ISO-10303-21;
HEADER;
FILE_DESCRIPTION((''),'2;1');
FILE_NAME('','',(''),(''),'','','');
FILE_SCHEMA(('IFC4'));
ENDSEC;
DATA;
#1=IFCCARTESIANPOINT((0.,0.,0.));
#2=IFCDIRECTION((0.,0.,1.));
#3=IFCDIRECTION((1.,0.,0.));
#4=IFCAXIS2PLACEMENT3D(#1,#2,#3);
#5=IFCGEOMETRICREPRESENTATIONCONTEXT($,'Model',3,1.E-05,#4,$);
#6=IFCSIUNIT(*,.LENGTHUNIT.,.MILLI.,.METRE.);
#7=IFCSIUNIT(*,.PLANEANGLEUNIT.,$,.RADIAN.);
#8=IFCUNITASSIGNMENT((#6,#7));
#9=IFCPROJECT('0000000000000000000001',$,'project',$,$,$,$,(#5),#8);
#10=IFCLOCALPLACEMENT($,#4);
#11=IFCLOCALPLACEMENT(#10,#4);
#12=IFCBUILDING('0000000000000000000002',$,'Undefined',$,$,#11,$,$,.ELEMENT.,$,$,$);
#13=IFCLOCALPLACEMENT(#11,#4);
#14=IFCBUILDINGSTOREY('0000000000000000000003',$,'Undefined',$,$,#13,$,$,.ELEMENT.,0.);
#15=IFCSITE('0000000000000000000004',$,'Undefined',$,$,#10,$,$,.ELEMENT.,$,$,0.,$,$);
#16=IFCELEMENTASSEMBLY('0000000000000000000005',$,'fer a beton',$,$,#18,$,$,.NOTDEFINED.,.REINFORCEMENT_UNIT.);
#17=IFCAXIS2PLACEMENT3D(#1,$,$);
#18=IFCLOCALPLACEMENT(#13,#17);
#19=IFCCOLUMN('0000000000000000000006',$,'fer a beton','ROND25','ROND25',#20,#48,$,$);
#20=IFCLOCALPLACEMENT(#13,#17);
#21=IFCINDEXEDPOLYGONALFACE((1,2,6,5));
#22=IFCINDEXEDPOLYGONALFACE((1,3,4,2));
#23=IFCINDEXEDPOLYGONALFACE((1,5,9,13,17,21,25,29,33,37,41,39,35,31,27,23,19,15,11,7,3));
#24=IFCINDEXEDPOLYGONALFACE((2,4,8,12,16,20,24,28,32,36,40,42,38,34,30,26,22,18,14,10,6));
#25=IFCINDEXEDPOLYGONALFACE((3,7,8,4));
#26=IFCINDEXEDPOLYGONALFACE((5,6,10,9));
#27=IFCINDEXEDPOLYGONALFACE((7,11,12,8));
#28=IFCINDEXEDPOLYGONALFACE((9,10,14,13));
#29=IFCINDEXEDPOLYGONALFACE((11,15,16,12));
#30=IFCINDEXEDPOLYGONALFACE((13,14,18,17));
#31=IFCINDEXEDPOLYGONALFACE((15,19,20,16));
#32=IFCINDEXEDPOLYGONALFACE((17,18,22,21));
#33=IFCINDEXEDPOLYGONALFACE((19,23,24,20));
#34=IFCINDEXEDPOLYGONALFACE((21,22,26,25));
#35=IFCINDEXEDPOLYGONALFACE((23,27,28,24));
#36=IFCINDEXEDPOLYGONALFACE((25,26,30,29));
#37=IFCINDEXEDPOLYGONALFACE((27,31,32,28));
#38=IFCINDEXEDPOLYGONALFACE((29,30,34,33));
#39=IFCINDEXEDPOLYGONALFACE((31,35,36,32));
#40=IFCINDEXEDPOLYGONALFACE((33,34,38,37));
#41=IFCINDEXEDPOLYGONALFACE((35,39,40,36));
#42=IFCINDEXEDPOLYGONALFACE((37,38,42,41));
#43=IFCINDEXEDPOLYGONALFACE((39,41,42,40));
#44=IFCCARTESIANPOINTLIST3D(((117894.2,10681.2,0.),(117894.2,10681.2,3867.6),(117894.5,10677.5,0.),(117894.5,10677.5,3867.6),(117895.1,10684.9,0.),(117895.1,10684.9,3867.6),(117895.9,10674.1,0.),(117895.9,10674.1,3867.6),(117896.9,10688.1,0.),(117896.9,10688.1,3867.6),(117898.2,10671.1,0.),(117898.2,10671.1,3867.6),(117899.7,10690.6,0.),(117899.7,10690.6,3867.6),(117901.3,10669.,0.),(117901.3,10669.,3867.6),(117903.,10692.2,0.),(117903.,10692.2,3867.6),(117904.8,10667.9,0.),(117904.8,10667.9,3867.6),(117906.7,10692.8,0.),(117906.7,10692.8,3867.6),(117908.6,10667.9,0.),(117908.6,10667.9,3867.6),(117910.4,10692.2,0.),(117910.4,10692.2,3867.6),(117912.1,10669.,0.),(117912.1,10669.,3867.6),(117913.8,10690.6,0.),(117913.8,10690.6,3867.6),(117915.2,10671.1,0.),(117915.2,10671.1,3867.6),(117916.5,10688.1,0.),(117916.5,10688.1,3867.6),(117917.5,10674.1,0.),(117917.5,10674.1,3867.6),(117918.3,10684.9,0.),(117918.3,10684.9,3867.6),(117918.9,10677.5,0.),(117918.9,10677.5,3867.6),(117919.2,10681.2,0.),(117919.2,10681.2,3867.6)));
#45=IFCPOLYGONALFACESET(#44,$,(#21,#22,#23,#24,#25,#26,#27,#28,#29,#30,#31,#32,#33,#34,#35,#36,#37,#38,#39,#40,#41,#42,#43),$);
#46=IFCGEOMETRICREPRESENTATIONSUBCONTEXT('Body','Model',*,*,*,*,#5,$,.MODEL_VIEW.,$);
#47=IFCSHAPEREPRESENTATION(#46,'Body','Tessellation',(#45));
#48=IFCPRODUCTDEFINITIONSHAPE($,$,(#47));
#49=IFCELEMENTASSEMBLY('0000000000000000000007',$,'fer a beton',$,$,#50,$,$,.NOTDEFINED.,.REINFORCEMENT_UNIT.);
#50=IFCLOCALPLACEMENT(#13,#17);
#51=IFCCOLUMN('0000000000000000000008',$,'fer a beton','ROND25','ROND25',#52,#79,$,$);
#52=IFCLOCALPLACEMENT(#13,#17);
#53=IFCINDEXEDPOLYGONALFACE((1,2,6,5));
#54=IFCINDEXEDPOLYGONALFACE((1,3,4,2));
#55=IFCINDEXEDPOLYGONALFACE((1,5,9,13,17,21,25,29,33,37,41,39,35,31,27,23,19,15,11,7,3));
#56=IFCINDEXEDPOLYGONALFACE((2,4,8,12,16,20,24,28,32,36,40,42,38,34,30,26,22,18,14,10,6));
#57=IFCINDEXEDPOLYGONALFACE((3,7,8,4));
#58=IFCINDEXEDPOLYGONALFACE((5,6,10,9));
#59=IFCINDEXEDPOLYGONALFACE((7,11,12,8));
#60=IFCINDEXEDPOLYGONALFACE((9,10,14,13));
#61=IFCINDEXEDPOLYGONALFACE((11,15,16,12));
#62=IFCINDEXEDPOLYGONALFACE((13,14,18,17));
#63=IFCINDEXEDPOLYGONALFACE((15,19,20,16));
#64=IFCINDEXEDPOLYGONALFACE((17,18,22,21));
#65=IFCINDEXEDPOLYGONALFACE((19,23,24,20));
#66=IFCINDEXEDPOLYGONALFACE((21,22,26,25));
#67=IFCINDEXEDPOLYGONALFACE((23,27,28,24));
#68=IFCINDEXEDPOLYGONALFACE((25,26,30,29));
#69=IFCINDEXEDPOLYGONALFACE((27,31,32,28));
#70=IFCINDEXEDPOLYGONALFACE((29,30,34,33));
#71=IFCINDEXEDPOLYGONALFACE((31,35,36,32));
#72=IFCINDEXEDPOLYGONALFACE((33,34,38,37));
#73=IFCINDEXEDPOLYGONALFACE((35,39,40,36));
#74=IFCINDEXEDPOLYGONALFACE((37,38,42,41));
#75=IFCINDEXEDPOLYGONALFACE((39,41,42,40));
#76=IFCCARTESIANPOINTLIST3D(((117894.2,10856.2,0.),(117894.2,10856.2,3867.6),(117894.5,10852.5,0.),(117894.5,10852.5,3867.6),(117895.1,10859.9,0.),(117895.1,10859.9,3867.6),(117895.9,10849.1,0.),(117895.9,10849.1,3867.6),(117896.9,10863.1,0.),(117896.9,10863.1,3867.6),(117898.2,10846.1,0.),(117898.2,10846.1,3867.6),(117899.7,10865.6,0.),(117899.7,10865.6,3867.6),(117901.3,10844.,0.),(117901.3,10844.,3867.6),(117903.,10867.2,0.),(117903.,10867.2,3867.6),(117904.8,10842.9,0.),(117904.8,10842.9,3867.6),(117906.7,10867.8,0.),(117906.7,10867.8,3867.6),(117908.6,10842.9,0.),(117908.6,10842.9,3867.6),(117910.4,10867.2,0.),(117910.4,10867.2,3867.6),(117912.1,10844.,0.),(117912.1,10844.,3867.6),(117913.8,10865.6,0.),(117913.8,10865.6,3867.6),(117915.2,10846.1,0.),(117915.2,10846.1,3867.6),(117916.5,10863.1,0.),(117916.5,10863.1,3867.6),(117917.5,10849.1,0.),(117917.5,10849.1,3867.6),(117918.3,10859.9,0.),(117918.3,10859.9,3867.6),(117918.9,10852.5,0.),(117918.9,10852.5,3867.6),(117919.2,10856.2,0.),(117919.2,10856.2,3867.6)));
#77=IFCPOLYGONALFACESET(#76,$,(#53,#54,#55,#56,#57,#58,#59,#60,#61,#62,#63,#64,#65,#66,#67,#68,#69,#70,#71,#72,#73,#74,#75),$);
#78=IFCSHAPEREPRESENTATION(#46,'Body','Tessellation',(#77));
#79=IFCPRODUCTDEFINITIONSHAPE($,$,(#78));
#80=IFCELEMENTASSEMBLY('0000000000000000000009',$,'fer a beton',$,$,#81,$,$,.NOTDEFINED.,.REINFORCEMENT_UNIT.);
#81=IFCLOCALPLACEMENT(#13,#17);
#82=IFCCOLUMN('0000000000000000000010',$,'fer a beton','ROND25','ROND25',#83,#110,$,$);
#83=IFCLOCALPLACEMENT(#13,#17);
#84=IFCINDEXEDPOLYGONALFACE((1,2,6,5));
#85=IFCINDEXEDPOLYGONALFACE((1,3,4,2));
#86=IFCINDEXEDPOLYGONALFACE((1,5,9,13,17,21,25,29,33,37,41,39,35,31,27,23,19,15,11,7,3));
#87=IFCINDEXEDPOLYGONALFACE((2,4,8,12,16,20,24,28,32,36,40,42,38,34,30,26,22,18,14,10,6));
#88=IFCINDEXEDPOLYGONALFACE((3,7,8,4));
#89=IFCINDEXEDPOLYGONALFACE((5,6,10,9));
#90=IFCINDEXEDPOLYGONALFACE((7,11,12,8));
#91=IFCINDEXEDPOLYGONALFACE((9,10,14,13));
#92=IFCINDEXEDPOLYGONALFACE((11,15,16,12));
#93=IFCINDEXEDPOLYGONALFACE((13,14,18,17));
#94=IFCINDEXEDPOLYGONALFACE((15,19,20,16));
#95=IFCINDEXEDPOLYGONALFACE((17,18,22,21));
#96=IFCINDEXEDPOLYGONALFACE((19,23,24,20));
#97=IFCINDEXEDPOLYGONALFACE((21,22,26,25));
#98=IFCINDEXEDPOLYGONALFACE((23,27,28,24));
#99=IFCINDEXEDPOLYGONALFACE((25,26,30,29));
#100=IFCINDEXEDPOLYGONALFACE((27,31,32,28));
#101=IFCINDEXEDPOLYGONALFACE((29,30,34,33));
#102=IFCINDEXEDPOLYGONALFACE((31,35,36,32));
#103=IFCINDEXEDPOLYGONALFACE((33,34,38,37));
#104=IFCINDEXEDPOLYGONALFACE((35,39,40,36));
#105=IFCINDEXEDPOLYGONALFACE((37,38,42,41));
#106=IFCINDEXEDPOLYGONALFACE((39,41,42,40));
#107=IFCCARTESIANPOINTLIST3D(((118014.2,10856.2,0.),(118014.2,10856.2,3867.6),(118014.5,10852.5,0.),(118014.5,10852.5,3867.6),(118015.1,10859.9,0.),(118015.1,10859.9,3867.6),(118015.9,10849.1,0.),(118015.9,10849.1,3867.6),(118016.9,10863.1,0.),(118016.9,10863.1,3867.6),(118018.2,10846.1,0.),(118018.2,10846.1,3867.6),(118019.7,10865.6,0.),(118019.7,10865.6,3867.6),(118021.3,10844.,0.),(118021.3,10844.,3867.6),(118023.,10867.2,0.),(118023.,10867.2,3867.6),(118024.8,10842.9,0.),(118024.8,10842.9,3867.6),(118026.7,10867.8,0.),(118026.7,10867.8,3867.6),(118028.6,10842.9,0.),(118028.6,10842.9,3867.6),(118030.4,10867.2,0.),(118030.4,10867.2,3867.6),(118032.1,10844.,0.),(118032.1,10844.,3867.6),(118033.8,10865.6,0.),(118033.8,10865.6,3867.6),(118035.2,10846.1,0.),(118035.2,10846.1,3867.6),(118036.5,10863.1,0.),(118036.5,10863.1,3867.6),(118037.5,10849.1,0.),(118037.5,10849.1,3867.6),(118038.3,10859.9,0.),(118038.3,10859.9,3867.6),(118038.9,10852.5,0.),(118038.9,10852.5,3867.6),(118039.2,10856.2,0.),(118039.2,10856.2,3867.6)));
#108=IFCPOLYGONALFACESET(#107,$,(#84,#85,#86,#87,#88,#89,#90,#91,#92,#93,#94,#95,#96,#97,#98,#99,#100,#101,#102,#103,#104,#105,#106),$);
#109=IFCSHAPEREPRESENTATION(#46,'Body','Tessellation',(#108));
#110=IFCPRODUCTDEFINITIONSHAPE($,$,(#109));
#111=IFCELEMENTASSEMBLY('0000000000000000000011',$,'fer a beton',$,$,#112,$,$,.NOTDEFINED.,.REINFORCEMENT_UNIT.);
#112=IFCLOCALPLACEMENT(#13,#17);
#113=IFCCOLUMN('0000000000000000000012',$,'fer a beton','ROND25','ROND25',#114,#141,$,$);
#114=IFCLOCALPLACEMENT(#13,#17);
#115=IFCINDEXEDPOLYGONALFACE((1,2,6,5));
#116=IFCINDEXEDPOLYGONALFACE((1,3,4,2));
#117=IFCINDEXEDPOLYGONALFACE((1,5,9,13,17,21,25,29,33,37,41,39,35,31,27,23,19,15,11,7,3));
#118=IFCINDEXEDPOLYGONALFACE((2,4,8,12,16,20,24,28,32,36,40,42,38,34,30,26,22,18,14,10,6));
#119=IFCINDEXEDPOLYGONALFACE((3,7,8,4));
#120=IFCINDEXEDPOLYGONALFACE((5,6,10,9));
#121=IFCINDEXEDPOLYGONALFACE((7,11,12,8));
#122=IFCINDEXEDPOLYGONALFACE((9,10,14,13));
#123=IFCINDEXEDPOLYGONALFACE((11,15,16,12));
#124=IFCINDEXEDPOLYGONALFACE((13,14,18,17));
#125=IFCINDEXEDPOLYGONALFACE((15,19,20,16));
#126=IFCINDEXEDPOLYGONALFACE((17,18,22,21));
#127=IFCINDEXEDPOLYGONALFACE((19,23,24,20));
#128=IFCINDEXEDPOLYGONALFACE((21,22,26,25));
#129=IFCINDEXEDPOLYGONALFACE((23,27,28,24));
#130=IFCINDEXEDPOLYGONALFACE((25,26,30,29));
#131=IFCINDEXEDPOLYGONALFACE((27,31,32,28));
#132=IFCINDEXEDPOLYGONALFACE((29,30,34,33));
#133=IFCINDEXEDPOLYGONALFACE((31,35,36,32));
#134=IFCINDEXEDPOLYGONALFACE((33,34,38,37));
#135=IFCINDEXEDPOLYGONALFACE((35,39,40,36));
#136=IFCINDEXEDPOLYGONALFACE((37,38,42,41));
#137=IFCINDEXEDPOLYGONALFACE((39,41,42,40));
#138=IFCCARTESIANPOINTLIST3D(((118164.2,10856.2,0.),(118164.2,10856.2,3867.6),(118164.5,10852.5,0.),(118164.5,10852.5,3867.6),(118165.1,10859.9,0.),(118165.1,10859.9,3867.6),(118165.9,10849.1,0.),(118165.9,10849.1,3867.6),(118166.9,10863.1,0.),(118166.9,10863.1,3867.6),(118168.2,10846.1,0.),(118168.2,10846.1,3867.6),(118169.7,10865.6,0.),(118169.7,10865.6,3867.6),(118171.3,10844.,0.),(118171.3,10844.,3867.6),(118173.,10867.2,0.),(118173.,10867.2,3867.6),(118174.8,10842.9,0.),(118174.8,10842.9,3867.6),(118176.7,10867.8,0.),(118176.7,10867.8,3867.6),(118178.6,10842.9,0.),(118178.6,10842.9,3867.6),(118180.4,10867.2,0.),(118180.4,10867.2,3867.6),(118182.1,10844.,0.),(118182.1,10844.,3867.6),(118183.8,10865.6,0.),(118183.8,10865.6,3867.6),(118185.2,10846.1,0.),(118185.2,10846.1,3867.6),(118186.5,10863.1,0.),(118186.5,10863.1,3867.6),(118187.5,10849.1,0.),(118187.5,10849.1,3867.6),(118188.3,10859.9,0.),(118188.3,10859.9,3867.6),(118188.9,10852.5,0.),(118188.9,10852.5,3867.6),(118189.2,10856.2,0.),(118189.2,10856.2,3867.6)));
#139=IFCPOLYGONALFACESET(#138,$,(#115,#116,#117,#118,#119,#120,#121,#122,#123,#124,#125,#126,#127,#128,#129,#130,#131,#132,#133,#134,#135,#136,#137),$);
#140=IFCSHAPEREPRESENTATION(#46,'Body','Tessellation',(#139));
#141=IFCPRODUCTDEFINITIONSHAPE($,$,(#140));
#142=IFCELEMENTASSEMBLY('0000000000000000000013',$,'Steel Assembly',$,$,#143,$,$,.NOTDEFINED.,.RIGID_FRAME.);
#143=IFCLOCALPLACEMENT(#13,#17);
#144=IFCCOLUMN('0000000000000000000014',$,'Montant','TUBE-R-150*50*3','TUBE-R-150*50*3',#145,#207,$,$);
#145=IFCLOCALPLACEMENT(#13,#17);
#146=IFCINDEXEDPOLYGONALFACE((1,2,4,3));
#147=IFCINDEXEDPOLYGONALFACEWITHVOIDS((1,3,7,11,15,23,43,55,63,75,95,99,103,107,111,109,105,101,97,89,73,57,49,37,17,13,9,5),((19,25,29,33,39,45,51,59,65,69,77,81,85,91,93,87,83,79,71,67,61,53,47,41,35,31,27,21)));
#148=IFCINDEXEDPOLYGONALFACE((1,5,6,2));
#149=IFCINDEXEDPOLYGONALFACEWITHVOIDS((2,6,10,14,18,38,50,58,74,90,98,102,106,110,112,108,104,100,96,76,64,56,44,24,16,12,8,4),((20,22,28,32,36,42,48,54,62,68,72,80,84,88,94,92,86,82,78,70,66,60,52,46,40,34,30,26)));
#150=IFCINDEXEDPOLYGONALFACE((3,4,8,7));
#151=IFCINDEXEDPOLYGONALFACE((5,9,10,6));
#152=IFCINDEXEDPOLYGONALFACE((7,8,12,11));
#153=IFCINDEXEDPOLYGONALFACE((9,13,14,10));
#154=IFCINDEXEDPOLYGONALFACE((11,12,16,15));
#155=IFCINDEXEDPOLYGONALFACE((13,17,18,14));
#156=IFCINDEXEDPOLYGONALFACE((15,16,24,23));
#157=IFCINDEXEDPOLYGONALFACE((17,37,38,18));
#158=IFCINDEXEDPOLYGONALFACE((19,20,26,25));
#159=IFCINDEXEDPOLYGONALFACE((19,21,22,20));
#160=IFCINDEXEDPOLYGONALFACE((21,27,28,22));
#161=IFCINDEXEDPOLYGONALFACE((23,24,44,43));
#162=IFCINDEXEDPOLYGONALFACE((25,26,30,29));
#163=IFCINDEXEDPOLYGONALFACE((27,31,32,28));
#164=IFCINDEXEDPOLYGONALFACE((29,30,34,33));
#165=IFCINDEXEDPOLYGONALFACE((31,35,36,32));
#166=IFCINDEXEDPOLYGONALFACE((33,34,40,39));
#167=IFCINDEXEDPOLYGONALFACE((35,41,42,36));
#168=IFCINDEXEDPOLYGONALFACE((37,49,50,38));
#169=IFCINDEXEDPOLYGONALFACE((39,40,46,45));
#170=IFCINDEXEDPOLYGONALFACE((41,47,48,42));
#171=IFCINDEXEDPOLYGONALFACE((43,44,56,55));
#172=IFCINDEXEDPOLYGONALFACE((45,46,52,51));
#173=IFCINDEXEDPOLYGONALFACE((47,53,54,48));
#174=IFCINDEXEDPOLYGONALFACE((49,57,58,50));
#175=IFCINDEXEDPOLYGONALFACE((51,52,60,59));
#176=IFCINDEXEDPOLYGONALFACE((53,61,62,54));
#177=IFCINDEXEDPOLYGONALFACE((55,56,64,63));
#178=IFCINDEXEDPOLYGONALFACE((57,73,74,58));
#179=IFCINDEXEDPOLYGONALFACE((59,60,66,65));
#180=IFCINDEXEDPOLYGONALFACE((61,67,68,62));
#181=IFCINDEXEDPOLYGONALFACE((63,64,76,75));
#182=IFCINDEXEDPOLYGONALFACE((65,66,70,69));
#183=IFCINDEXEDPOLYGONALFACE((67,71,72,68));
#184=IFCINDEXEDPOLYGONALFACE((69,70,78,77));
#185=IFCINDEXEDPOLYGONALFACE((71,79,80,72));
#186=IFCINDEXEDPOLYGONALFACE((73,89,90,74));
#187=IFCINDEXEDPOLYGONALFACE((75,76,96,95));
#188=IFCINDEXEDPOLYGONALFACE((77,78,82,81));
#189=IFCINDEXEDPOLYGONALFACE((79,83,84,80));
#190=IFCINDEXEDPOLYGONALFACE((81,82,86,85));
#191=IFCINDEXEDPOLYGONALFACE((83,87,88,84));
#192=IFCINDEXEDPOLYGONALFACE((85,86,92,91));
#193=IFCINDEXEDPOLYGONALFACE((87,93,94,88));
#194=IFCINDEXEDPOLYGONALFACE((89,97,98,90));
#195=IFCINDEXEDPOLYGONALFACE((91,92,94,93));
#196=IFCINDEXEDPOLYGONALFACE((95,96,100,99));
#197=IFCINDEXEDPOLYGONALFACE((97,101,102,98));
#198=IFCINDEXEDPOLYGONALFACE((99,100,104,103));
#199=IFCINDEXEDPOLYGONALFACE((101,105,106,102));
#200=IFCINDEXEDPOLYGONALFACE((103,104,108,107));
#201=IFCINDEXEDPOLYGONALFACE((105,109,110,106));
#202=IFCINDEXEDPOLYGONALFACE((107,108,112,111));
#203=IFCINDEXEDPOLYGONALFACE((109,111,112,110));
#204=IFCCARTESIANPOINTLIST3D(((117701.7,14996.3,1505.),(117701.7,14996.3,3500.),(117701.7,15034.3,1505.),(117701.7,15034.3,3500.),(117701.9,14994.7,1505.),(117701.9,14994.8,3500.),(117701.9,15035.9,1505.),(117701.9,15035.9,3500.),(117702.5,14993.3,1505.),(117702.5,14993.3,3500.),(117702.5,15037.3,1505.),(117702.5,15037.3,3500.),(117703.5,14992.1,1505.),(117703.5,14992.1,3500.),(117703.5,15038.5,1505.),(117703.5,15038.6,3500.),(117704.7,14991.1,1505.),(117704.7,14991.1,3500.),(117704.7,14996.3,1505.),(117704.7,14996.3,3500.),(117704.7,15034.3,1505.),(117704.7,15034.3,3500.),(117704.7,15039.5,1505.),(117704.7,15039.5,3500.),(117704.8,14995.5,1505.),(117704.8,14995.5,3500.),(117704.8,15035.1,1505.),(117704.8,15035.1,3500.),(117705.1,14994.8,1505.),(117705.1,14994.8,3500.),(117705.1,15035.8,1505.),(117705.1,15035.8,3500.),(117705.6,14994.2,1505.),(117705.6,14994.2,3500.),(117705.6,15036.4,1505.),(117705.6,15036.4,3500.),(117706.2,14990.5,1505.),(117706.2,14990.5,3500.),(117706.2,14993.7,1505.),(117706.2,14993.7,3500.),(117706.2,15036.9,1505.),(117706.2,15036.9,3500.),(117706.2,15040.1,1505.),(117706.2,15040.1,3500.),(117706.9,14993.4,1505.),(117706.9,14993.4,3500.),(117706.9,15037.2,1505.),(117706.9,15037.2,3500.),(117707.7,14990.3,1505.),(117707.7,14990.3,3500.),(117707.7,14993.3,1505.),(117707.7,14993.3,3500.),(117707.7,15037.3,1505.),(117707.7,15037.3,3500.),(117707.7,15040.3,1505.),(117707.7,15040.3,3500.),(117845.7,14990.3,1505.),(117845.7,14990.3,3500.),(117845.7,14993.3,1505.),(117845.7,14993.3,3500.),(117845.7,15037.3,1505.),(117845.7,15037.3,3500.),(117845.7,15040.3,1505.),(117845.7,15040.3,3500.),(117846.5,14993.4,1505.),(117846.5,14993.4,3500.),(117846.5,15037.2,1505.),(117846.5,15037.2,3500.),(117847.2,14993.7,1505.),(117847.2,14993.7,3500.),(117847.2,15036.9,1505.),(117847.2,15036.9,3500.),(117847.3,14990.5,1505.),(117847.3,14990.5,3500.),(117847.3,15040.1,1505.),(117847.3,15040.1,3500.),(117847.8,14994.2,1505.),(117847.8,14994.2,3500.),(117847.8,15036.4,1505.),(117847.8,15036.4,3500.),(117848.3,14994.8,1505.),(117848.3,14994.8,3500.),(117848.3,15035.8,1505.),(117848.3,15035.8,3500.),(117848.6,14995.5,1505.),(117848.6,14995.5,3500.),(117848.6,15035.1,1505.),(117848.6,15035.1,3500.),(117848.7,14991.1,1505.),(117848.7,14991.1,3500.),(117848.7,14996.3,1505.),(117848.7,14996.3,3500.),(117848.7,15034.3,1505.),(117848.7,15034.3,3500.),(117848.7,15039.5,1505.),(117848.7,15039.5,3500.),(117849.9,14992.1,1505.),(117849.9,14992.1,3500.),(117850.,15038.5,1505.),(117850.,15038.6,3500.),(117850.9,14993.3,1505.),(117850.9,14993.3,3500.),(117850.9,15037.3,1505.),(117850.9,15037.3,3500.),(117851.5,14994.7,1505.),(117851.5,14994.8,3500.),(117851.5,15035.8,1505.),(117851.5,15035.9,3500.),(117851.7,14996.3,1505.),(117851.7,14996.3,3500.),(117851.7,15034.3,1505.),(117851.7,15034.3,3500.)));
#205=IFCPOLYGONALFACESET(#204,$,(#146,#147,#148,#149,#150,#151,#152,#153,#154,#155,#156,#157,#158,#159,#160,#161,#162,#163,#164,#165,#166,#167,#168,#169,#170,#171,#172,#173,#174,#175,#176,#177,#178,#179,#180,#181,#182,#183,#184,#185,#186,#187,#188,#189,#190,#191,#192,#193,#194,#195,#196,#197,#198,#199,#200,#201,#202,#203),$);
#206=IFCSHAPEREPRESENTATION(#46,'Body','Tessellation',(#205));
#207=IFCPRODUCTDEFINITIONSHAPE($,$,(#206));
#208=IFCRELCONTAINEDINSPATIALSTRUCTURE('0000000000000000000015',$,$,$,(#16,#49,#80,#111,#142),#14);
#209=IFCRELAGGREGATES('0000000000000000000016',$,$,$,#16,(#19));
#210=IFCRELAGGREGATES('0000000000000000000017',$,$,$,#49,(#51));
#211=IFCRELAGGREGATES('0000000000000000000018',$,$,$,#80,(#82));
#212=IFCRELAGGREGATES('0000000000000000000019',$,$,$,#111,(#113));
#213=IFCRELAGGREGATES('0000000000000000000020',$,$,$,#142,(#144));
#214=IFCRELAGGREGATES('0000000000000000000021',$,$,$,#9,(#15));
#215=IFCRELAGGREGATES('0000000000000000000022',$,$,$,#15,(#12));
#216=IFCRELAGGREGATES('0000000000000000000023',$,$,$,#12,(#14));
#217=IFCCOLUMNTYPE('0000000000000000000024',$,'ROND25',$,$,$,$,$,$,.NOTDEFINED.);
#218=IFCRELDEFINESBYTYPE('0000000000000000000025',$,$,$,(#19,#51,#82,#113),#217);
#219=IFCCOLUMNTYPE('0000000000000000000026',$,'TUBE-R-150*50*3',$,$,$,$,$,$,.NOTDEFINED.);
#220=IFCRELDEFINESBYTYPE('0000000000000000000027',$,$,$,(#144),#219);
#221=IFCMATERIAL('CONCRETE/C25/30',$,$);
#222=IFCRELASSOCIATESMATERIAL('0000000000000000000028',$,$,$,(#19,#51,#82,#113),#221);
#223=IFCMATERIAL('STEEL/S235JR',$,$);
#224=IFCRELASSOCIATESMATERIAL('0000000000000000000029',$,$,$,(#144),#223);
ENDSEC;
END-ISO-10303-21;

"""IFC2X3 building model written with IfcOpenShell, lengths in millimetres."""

from ifc_helpers import new_model, si_unit, frame, origin_with_axes, origin_2d_with_axis, place, context, subcontext, project, spatial, hollow_rectangle, circle, extrude, material, type_object, element, aggregate, save


model = new_model("IFC2X3")

# Units and contexts
model_context = context("Model", 3, precision=1e-05, world=origin_with_axes())
body_context = subcontext(model_context, "Body", "Model", "MODEL_VIEW")
ifc_project = project(units=[si_unit("LENGTHUNIT", "METRE", prefix="MILLI"), si_unit("PLANEANGLEUNIT", "RADIAN")], contexts=[model_context])

# Site, building, storey
site_placement = place(None, origin_with_axes())
site = spatial("IfcSite", under=ifc_project, at=site_placement, Name="Undefined", CompositionType="ELEMENT", RefElevation=0.0)
building_placement = place(site_placement, origin_with_axes())
building = spatial("IfcBuilding", under=site, at=building_placement, Name="Undefined", CompositionType="ELEMENT")
storey_placement = place(building_placement, origin_with_axes())
storey = spatial("IfcBuildingStorey", under=building, at=storey_placement, Name="Undefined", CompositionType="ELEMENT", Elevation=0.0)

# Element assemblies, columns
assembly_1_placement = place(storey_placement, origin_with_axes())
assembly_1 = element("IfcElementAssembly", 1, at=assembly_1_placement, inside=storey, Name="fer a beton", AssemblyPlace="NOTDEFINED", PredefinedType="REINFORCEMENT_UNIT")
ifc_material_1 = material(Name="CONCRETE/C25/30")
column_type_1 = type_object("IfcColumnType", Name="ROND25", PredefinedType="NOTDEFINED")
column_1_placement = place(assembly_1_placement, frame((117906.7, 10680.3, 0.0), z_axis=(0.0, 0.0, 1.0), x_axis=(1.0, 0.0, 0.0)))
column_1 = element("IfcColumn", 2, at=column_1_placement, type_object=column_type_1, material=ifc_material_1, Name="fer a beton", Description="ROND25", ObjectType="ROND25", context=body_context, shape_type="SweptSolid", body=[
    extrude(circle(Radius=12.5, at=origin_2d_with_axis()), frame((0.0, 0.0, 3867.6), z_axis=(0.0, 0.0, -1.0), x_axis=(0.0, 1.0, 0.0)), (0.0, 0.0, 1.0), 3867.6),
])
aggregate(assembly_1, [column_1])
assembly_2_placement = place(storey_placement, origin_with_axes())
assembly_2 = element("IfcElementAssembly", 3, at=assembly_2_placement, inside=storey, Name="fer a beton", AssemblyPlace="NOTDEFINED", PredefinedType="REINFORCEMENT_UNIT")
column_2_placement = place(assembly_2_placement, frame((117906.7, 10855.3, 0.0), z_axis=(0.0, 0.0, 1.0), x_axis=(1.0, 0.0, 0.0)))
column_2 = element("IfcColumn", 4, at=column_2_placement, type_object=column_type_1, material=ifc_material_1, Name="fer a beton", Description="ROND25", ObjectType="ROND25", context=body_context, shape_type="SweptSolid", body=[
    extrude(circle(Radius=12.5, at=origin_2d_with_axis()), frame((0.0, 0.0, 3867.6), z_axis=(0.0, 0.0, -1.0), x_axis=(0.0, 1.0, 0.0)), (0.0, 0.0, 1.0), 3867.6),
])
aggregate(assembly_2, [column_2])
assembly_3_placement = place(storey_placement, origin_with_axes())
assembly_3 = element("IfcElementAssembly", 5, at=assembly_3_placement, inside=storey, Name="fer a beton", AssemblyPlace="NOTDEFINED", PredefinedType="REINFORCEMENT_UNIT")
column_3_placement = place(assembly_3_placement, frame((118026.7, 10855.3, 0.0), z_axis=(0.0, 0.0, 1.0), x_axis=(1.0, 0.0, 0.0)))
column_3 = element("IfcColumn", 6, at=column_3_placement, type_object=column_type_1, material=ifc_material_1, Name="fer a beton", Description="ROND25", ObjectType="ROND25", context=body_context, shape_type="SweptSolid", body=[
    extrude(circle(Radius=12.5, at=origin_2d_with_axis()), frame((0.0, 0.0, 3867.6), z_axis=(0.0, 0.0, -1.0), x_axis=(0.0, 1.0, 0.0)), (0.0, 0.0, 1.0), 3867.6),
])
aggregate(assembly_3, [column_3])
assembly_4_placement = place(storey_placement, origin_with_axes())
assembly_4 = element("IfcElementAssembly", 7, at=assembly_4_placement, inside=storey, Name="fer a beton", AssemblyPlace="NOTDEFINED", PredefinedType="REINFORCEMENT_UNIT")
column_4_placement = place(assembly_4_placement, frame((118176.7, 10855.3, 0.0), z_axis=(0.0, 0.0, 1.0), x_axis=(1.0, 0.0, 0.0)))
column_4 = element("IfcColumn", 8, at=column_4_placement, type_object=column_type_1, material=ifc_material_1, Name="fer a beton", Description="ROND25", ObjectType="ROND25", context=body_context, shape_type="SweptSolid", body=[
    extrude(circle(Radius=12.5, at=origin_2d_with_axis()), frame((0.0, 0.0, 3867.6), z_axis=(0.0, 0.0, -1.0), x_axis=(0.0, 1.0, 0.0)), (0.0, 0.0, 1.0), 3867.6),
])
aggregate(assembly_4, [column_4])
assembly_5_placement = place(storey_placement, origin_with_axes())
assembly_5 = element("IfcElementAssembly", 9, at=assembly_5_placement, inside=storey, Name="Steel Assembly", AssemblyPlace="NOTDEFINED", PredefinedType="RIGID_FRAME")
ifc_material_2 = material(Name="STEEL/S235JR")
column_type_2 = type_object("IfcColumnType", Name="TUBE-R-150*50*3", PredefinedType="NOTDEFINED")
column_5_placement = place(assembly_5_placement, frame((117776.7, 15015.3, 1505.0), z_axis=(0.0, 0.0, 1.0), x_axis=(1.0, 0.0, 0.0)))
column_5 = element("IfcColumn", 10, at=column_5_placement, type_object=column_type_2, material=ifc_material_2, Name="Montant", Description="TUBE-R-150*50*3", ObjectType="TUBE-R-150*50*3", context=body_context, shape_type="SweptSolid", body=[
    extrude(hollow_rectangle(XDim=50.0, YDim=150.0, WallThickness=3.0, InnerFilletRadius=3.0, OuterFilletRadius=6.0, at=origin_2d_with_axis()), frame((0.0, 0.0, 1995.0), z_axis=(0.0, -0.000011, -1.0), x_axis=(-0.000045, -1.0, 0.000011)), (0.0, 0.0, 1.0), 1995.0),
])
aggregate(assembly_5, [column_5])

save(model, "model.ifc")
